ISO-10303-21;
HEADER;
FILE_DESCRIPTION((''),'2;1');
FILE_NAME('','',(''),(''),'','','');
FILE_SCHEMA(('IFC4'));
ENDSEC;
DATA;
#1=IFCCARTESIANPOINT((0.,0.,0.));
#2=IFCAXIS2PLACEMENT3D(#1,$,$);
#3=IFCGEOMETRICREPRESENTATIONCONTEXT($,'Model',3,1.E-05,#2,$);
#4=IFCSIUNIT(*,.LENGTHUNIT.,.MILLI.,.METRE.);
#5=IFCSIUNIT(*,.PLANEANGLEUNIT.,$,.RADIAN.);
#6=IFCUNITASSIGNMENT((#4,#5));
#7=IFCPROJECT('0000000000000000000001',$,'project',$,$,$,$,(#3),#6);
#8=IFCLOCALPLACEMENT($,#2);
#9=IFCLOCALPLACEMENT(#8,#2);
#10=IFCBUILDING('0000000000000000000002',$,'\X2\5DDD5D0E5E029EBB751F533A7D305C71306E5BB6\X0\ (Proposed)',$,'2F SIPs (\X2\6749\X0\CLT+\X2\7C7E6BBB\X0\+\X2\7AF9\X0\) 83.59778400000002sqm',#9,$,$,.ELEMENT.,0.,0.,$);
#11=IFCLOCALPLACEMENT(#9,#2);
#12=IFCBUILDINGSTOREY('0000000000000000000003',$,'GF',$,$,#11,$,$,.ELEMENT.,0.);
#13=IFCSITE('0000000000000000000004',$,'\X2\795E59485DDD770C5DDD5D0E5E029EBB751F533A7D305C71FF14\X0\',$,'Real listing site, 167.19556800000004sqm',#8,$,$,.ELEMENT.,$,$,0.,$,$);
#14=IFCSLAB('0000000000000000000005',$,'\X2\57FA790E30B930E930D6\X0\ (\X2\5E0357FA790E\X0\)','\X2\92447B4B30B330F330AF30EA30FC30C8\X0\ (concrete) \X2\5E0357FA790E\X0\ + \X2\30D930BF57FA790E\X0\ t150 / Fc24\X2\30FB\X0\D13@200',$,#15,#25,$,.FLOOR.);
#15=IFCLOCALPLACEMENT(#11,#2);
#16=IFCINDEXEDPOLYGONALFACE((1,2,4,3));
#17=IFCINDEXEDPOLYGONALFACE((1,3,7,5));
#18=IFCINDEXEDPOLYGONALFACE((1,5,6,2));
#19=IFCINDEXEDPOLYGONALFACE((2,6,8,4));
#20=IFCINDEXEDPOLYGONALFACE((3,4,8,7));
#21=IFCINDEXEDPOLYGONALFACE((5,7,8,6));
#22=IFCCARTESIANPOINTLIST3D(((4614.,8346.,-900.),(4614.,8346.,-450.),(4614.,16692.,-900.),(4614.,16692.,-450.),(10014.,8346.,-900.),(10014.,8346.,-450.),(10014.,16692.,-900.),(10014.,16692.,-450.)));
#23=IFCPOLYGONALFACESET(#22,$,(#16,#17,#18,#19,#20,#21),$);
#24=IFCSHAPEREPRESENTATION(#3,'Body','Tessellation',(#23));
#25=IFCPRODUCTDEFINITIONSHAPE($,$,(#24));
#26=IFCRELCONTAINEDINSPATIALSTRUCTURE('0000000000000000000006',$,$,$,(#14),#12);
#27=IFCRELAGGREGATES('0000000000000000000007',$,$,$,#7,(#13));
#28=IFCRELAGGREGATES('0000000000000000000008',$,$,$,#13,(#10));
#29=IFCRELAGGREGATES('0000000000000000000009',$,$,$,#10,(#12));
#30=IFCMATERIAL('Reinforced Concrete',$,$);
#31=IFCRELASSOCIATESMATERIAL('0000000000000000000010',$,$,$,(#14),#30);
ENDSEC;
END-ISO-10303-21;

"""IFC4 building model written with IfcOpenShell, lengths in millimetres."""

from ifc_helpers import new_model, si_unit, frame, frame_2d, origin, place, context, project, spatial, rectangle, extrude, material, element, save


model = new_model("IFC4")

# Units and contexts
model_context = context("Model", 3, precision=1e-05, world=origin())
ifc_project = project(units=[si_unit("LENGTHUNIT", "METRE", prefix="MILLI"), si_unit("PLANEANGLEUNIT", "RADIAN")], contexts=[model_context])

# Site, building, storey
site_placement = place(None, origin())
site = spatial("IfcSite", under=ifc_project, at=site_placement, Name="神奈川県川崎市麻生区細山４", ObjectType="Real listing site, 167.19556800000004sqm", CompositionType="ELEMENT", RefElevation=0.0)
building_placement = place(site_placement, origin())
building = spatial("IfcBuilding", under=site, at=building_placement, Name="川崎市麻生区細山の家 (Proposed)", ObjectType="2F SIPs (杉CLT+籾殻+竹) 83.59778400000002sqm", CompositionType="ELEMENT", ElevationOfRefHeight=0.0, ElevationOfTerrain=0.0)
storey_placement = place(building_placement, origin())
storey = spatial("IfcBuildingStorey", under=building, at=storey_placement, Name="GF", CompositionType="ELEMENT", Elevation=0.0)

# Slab
ifc_material_1 = material(Name="Reinforced Concrete")
slab_1_placement = place(storey_placement, frame((2307.0, 4173.0, -450.0)))
element("IfcSlab", 1, at=slab_1_placement, inside=storey, material=ifc_material_1, Name="基礎スラブ (布基礎)", Description="鉄筋コンクリート (concrete) 布基礎 + ベタ基礎 t150 / Fc24・D13@200", PredefinedType="FLOOR", context=model_context, shape_type="SweptSolid", body=[
    extrude(rectangle(XDim=5400.0, YDim=8346.0, at=frame_2d((2700.0, 4173.0))), frame((2307.0, 4173.0, -450.0)), (0.0, 0.0, 1.0), 450.0),
])

save(model, "model.ifc")
